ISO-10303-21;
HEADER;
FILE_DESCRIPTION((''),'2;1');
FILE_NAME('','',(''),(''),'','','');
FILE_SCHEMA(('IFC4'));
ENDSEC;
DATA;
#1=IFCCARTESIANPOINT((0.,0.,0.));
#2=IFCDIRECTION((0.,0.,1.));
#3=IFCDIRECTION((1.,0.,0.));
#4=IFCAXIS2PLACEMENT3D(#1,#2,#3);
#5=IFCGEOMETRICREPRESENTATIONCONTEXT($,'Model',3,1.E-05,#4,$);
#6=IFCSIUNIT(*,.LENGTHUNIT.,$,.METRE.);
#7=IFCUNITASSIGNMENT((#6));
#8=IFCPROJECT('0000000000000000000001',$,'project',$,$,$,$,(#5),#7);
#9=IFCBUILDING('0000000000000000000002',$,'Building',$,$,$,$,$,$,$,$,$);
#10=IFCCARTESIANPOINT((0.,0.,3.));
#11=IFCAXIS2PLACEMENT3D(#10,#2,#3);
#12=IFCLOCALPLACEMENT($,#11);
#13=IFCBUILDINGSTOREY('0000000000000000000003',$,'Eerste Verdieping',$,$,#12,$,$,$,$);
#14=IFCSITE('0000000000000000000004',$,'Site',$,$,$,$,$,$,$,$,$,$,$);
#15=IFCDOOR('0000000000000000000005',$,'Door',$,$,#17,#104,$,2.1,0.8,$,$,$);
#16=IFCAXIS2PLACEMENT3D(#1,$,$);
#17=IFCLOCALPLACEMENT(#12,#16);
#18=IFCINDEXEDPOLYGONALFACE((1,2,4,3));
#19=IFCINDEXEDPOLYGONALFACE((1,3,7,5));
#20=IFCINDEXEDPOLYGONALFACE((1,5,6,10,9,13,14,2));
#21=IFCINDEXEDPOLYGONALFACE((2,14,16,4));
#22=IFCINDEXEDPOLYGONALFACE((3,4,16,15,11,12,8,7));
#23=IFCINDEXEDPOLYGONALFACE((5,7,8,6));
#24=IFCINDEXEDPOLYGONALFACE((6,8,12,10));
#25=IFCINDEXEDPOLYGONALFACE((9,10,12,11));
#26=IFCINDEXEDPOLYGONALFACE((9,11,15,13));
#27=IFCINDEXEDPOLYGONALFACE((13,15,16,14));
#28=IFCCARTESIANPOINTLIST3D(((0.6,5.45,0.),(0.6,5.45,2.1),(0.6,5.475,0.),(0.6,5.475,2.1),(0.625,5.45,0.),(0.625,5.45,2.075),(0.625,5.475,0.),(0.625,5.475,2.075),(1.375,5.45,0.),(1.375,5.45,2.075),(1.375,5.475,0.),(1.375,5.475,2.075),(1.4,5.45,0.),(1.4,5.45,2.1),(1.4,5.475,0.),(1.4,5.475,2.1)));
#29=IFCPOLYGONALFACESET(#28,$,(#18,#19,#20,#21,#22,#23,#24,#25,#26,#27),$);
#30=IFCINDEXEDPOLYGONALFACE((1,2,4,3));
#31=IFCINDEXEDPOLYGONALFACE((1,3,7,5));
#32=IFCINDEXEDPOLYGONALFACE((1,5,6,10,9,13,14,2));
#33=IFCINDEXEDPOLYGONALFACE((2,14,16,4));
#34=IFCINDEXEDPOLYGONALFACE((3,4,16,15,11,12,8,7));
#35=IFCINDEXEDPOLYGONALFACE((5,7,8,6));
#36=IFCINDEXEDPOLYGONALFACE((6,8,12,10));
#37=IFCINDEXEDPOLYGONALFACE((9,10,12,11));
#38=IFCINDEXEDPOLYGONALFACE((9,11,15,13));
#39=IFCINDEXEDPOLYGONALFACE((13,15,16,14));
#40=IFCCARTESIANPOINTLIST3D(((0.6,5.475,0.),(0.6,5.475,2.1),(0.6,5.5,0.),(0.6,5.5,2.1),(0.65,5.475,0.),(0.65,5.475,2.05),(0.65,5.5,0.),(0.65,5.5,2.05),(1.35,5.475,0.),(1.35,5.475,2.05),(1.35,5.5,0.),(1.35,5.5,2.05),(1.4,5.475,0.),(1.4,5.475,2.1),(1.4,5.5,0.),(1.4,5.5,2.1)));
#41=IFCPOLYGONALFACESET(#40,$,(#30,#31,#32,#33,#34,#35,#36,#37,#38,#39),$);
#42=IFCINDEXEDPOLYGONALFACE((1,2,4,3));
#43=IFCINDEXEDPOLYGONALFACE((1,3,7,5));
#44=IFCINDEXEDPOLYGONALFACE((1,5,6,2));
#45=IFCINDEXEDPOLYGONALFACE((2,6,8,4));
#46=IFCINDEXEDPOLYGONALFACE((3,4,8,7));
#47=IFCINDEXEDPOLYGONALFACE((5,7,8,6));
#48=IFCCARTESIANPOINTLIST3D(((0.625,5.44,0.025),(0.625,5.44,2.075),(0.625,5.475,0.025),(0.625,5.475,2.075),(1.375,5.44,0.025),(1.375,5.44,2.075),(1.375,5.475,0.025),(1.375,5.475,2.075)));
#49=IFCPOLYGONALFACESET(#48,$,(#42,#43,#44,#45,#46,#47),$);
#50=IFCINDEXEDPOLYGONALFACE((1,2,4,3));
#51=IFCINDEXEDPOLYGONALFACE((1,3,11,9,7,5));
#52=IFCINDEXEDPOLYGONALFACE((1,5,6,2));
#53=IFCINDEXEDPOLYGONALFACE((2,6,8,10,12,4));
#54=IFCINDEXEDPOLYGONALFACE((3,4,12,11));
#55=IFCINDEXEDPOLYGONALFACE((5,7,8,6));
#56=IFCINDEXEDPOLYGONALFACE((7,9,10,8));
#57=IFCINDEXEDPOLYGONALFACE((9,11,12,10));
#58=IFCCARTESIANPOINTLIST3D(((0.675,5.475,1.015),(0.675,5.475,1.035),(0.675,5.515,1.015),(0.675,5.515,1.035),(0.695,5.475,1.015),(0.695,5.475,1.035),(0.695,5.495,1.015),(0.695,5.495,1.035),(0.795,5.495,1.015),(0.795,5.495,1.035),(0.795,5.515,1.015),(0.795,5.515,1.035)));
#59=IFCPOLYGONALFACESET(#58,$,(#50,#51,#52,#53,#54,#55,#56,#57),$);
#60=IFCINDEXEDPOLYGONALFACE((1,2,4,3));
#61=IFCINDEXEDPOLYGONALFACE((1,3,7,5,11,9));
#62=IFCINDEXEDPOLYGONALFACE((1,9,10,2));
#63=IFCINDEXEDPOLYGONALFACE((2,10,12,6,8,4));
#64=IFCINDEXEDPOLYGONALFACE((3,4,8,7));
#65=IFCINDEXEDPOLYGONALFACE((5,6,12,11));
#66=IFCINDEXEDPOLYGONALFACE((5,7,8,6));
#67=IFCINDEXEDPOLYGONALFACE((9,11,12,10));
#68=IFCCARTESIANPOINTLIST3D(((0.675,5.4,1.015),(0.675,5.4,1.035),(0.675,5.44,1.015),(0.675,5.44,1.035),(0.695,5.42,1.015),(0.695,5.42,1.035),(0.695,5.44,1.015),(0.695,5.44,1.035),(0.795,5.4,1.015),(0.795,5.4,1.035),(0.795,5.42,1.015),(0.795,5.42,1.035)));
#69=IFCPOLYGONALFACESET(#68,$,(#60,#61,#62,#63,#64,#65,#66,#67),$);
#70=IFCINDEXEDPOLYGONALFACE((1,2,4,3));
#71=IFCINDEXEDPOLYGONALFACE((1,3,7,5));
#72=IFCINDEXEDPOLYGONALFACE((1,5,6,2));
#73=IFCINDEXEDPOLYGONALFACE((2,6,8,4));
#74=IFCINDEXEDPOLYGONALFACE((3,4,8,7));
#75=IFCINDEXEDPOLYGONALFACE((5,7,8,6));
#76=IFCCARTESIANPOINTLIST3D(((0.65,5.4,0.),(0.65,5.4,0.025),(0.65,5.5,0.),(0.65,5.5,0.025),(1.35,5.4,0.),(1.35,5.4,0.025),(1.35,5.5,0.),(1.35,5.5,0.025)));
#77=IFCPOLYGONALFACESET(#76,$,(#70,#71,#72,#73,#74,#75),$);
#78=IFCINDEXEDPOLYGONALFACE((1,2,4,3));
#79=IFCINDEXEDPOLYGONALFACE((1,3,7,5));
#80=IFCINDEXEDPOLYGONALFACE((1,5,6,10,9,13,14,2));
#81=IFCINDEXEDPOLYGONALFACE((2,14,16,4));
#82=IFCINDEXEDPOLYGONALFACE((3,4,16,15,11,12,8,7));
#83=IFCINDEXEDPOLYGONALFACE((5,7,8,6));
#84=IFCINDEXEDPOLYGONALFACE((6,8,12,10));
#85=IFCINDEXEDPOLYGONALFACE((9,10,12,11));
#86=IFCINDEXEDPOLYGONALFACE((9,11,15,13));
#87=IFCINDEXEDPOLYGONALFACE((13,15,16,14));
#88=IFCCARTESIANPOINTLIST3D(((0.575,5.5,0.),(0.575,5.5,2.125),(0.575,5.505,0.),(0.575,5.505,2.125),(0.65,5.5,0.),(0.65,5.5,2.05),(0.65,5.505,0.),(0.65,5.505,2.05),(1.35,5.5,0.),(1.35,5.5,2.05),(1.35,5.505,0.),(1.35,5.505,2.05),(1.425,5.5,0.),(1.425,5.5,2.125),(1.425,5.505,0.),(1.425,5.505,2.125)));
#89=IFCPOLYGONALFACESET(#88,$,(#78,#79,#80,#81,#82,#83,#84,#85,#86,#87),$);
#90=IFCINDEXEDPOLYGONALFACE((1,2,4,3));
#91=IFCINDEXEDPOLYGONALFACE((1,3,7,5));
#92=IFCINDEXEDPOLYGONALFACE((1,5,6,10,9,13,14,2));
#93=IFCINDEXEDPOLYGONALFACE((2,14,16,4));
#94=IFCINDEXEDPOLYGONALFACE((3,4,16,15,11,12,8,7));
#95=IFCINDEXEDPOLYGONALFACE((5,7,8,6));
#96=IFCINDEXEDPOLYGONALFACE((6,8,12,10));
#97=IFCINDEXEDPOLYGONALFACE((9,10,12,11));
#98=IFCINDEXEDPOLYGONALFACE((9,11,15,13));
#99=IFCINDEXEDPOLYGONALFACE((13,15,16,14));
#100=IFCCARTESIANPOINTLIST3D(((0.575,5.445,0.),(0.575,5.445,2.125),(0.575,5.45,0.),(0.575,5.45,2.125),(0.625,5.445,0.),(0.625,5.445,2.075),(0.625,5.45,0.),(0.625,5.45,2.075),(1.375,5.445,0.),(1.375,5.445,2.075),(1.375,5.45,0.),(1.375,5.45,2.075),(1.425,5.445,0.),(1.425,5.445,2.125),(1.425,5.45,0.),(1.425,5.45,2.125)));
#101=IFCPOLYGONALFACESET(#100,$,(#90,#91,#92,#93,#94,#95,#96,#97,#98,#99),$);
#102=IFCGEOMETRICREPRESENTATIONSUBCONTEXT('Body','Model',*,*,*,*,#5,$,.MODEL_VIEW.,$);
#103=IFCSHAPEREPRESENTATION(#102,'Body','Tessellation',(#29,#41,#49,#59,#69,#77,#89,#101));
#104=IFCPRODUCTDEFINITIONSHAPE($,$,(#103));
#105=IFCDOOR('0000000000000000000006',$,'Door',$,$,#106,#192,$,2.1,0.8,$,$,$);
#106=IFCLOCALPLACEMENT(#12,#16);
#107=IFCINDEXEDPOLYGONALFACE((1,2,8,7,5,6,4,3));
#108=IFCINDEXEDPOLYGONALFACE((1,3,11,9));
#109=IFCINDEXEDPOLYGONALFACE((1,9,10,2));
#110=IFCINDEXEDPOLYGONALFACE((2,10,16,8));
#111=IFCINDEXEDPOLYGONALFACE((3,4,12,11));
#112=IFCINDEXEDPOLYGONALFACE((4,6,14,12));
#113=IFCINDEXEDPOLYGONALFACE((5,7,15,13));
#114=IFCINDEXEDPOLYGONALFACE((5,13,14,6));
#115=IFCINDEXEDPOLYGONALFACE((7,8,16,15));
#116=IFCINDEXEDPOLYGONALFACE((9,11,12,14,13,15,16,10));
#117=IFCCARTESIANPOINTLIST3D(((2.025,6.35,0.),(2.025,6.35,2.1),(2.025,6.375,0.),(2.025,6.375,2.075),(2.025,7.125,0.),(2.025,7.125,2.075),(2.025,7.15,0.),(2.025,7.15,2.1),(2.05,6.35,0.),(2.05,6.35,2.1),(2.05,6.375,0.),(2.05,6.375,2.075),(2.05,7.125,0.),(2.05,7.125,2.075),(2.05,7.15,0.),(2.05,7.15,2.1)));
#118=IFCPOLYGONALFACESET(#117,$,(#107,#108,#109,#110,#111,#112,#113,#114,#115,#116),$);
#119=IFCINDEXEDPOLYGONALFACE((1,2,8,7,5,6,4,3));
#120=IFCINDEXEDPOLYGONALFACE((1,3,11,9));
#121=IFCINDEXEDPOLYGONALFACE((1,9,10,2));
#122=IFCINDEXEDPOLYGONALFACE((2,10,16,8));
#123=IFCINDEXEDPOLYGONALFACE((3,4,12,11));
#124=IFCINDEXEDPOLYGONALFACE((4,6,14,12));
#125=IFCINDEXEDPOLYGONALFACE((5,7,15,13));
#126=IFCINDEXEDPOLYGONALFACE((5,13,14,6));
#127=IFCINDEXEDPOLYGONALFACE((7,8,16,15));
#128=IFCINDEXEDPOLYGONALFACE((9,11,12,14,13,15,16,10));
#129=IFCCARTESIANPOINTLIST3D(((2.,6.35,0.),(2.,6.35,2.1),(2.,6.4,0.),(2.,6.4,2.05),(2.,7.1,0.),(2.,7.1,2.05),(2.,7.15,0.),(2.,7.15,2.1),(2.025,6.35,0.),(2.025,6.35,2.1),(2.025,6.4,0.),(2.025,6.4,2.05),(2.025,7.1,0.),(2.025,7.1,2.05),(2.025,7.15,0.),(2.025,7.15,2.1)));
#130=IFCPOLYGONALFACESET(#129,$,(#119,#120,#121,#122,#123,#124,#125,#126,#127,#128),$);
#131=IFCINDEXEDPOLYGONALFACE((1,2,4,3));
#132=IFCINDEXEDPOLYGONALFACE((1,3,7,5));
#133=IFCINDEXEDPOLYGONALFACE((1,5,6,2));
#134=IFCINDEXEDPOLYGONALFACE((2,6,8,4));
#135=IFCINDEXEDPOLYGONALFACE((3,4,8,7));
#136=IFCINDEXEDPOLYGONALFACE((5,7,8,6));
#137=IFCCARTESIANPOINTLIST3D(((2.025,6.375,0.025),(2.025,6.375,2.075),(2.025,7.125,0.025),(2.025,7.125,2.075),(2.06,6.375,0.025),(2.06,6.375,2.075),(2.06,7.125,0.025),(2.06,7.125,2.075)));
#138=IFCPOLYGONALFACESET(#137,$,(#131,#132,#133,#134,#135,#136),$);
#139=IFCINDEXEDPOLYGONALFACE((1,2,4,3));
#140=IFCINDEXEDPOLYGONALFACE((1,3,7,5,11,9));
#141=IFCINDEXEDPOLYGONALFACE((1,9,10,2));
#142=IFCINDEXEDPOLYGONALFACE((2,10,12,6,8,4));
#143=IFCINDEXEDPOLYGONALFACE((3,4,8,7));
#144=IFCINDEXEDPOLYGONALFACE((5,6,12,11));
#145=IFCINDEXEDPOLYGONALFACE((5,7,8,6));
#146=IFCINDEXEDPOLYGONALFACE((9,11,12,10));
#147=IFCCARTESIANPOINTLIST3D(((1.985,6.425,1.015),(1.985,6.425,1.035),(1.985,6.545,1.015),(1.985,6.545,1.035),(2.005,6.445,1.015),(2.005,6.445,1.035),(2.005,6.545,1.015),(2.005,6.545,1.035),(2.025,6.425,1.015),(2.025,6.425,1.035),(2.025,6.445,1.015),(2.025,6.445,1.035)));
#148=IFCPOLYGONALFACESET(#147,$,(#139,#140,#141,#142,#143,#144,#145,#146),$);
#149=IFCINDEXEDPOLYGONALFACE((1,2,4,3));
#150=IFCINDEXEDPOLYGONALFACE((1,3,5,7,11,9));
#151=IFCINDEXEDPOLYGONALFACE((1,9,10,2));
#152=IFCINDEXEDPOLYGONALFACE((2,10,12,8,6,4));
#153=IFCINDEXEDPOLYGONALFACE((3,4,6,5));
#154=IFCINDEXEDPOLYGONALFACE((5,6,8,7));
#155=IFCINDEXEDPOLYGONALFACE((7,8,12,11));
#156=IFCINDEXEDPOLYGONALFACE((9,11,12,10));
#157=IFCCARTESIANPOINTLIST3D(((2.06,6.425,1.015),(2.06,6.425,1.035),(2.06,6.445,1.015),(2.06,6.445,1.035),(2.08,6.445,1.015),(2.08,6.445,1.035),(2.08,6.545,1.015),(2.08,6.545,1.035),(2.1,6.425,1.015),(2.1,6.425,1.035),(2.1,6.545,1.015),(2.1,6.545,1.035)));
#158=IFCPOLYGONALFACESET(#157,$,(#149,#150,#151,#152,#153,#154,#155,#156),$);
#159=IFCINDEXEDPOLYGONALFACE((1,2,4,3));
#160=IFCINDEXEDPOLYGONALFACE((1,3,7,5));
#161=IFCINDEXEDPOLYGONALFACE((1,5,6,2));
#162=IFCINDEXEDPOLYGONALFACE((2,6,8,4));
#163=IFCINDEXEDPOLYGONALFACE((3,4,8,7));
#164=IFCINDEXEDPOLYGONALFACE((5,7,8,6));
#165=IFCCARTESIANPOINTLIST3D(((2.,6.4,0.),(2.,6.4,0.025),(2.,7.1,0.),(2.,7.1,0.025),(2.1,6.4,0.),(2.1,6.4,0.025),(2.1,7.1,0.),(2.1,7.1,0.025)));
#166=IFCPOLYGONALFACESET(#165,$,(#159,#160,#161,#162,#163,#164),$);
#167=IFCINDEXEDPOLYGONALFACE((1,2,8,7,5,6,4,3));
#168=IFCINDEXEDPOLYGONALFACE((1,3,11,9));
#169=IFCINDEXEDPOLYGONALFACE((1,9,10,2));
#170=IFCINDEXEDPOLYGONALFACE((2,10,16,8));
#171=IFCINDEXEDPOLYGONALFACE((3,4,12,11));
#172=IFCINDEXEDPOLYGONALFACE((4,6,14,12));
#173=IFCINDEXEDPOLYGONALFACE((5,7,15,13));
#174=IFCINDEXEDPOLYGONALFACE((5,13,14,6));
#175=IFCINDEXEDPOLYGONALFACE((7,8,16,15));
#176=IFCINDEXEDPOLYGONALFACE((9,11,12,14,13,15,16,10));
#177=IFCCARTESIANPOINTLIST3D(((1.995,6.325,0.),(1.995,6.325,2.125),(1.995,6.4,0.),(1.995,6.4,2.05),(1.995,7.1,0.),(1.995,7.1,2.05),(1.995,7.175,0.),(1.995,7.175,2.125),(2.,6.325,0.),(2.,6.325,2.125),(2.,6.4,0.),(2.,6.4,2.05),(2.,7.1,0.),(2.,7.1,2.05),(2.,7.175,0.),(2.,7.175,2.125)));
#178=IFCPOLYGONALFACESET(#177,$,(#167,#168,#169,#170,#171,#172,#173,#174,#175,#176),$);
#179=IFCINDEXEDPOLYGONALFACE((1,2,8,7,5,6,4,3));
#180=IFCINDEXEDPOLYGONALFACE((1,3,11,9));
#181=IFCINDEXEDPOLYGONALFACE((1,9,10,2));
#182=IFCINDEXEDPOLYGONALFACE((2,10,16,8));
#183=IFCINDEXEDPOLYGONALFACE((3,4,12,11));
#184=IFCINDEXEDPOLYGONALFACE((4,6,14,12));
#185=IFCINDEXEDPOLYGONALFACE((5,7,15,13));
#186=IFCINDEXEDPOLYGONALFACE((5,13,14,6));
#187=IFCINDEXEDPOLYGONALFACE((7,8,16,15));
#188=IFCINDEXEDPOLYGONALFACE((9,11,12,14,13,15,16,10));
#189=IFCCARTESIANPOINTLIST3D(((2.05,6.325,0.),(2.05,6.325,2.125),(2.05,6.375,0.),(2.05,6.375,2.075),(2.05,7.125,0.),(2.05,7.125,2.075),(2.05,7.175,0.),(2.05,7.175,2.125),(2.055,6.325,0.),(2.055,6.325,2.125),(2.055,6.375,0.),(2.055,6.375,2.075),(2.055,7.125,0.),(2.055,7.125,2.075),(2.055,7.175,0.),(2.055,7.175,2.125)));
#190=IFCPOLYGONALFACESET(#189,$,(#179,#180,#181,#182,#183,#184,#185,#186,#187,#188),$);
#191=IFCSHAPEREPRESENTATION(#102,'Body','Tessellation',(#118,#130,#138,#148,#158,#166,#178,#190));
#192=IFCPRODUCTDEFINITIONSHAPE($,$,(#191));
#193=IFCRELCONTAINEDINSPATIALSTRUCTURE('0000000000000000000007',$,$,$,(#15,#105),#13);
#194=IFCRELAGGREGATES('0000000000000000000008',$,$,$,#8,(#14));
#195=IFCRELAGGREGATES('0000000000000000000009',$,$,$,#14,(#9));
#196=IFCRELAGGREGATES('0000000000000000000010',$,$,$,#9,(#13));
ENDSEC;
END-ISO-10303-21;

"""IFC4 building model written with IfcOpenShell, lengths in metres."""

from ifc_helpers import new_model, si_unit, frame, origin_with_axes, place, context, subcontext, project, spatial, line, indexed_curve, outline, extrude, element, save


model = new_model("IFC4")

# Units and contexts
model_context = context("Model", 3, precision=1e-05, world=origin_with_axes())
body_context = subcontext(model_context, "Body", "Model", "MODEL_VIEW")
ifc_project = project(units=[si_unit("LENGTHUNIT", "METRE")], contexts=[model_context])

# Site, building, storey
site = spatial("IfcSite", under=ifc_project, Name="Site")
building = spatial("IfcBuilding", under=site, Name="Building")
storey_placement = place(None, frame((0.0, 0.0, 3.0), z_axis=(0.0, 0.0, 1.0), x_axis=(1.0, 0.0, 0.0)))
storey = spatial("IfcBuildingStorey", under=building, at=storey_placement, Name="Eerste Verdieping")

# Doors
door_1_placement = place(storey_placement, frame((1.4, 5.5, 0.0), z_axis=(0.0, 0.0, 1.0), x_axis=(-1.0, 0.0, 0.0)))
element("IfcDoor", 1, at=door_1_placement, inside=storey, Name="Door", OverallHeight=2.1, OverallWidth=0.8, context=body_context, shape_type="SweptSolid", body=[
    extrude(outline(indexed_curve([(0.0, 0.0), (0.0, 2.1), (0.8, 2.1), (0.8, 0.0), (0.775, 0.0), (0.775, 2.075), (0.025, 2.075), (0.025, 0.0)], segments=[line(1, 2, 3, 4, 5, 6, 7, 8, 1)])), frame((0.0, 0.025, 0.0), z_axis=(0.0, -1.0, 0.0), x_axis=(1.0, 0.0, 0.0)), (0.0, 0.0, -1.0), 0.025),
    extrude(outline(indexed_curve([(0.0, 0.0), (0.0, 2.1), (0.8, 2.1), (0.8, 0.0), (0.75, 0.0), (0.75, 2.05), (0.05, 2.05), (0.05, 0.0)], segments=[line(1, 2, 3, 4, 5, 6, 7, 8, 1)])), frame((0.0, 0.0, 0.0), z_axis=(0.0, -1.0, 0.0), x_axis=(1.0, 0.0, 0.0)), (0.0, 0.0, -1.0), 0.025),
    extrude(outline(indexed_curve([(0.0, 0.0), (0.75, 0.0), (0.75, 0.035), (0.0, 0.035)], segments=[line(1, 2, 3, 4, 1)])), frame((0.025, 0.025, 0.025), z_axis=(0.0, 0.0, 1.0), x_axis=(1.0, 0.0, 0.0)), (0.0, 0.0, 1.0), 2.05),
    extrude(outline(indexed_curve([(0.0, 0.0), (0.0, -0.04), (-0.12, -0.04), (-0.12, -0.02), (-0.02, -0.02), (-0.02, 0.0)], segments=[line(1, 2, 3, 4, 5, 6, 1)])), frame((0.725, 0.025, 1.015), z_axis=(0.0, 0.0, 1.0), x_axis=(1.0, 0.0, 0.0)), (0.0, 0.0, 1.0), 0.02),
    extrude(outline(indexed_curve([(0.0, 0.0), (0.0, 0.04), (-0.12, 0.04), (-0.12, 0.02), (-0.02, 0.02), (-0.02, 0.0)], segments=[line(1, 2, 3, 4, 5, 6, 1)])), frame((0.725, 0.06, 1.015), z_axis=(0.0, 0.0, 1.0), x_axis=(1.0, 0.0, 0.0)), (0.0, 0.0, 1.0), 0.02),
    extrude(outline(indexed_curve([(0.0, 0.0), (0.7, 0.0), (0.7, 0.1), (0.0, 0.1)], segments=[line(1, 2, 3, 4, 1)])), frame((0.05, 0.0, 0.0), z_axis=(0.0, 0.0, 1.0), x_axis=(1.0, 0.0, 0.0)), (0.0, 0.0, 1.0), 0.025),
    extrude(outline(indexed_curve([(0.0, 0.0), (0.0, 2.125), (0.85, 2.125), (0.85, 0.0), (0.775, 0.0), (0.775, 2.05), (0.075, 2.05), (0.075, 0.0)], segments=[line(1, 2, 3, 4, 5, 6, 7, 8, 1)])), frame((-0.025, -0.005, 0.0), z_axis=(0.0, -1.0, 0.0), x_axis=(1.0, 0.0, 0.0)), (0.0, 0.0, -1.0), 0.005),
    extrude(outline(indexed_curve([(0.0, 0.0), (0.0, 2.125), (0.85, 2.125), (0.85, 0.0), (0.8, 0.0), (0.8, 2.075), (0.05, 2.075), (0.05, 0.0)], segments=[line(1, 2, 3, 4, 5, 6, 7, 8, 1)])), frame((-0.025, 0.05, 0.0), z_axis=(0.0, -1.0, 0.0), x_axis=(1.0, 0.0, 0.0)), (0.0, 0.0, -1.0), 0.005),
])
door_2_placement = place(storey_placement, frame((2.0, 7.15, 0.0), z_axis=(0.0, 0.0, 1.0), x_axis=(0.0, -1.0, 0.0)))
element("IfcDoor", 2, at=door_2_placement, inside=storey, Name="Door", OverallHeight=2.1, OverallWidth=0.8, context=body_context, shape_type="SweptSolid", body=[
    extrude(outline(indexed_curve([(0.0, 0.0), (0.0, 2.1), (0.8, 2.1), (0.8, 0.0), (0.775, 0.0), (0.775, 2.075), (0.025, 2.075), (0.025, 0.0)], segments=[line(1, 2, 3, 4, 5, 6, 7, 8, 1)])), frame((0.0, 0.025, 0.0), z_axis=(0.0, -1.0, 0.0), x_axis=(1.0, 0.0, 0.0)), (0.0, 0.0, -1.0), 0.025),
    extrude(outline(indexed_curve([(0.0, 0.0), (0.0, 2.1), (0.8, 2.1), (0.8, 0.0), (0.75, 0.0), (0.75, 2.05), (0.05, 2.05), (0.05, 0.0)], segments=[line(1, 2, 3, 4, 5, 6, 7, 8, 1)])), frame((0.0, 0.0, 0.0), z_axis=(0.0, -1.0, 0.0), x_axis=(1.0, 0.0, 0.0)), (0.0, 0.0, -1.0), 0.025),
    extrude(outline(indexed_curve([(0.0, 0.0), (0.75, 0.0), (0.75, 0.035), (0.0, 0.035)], segments=[line(1, 2, 3, 4, 1)])), frame((0.025, 0.025, 0.025), z_axis=(0.0, 0.0, 1.0), x_axis=(1.0, 0.0, 0.0)), (0.0, 0.0, 1.0), 2.05),
    extrude(outline(indexed_curve([(0.0, 0.0), (0.0, -0.04), (-0.12, -0.04), (-0.12, -0.02), (-0.02, -0.02), (-0.02, 0.0)], segments=[line(1, 2, 3, 4, 5, 6, 1)])), frame((0.725, 0.025, 1.015), z_axis=(0.0, 0.0, 1.0), x_axis=(1.0, 0.0, 0.0)), (0.0, 0.0, 1.0), 0.02),
    extrude(outline(indexed_curve([(0.0, 0.0), (0.0, 0.04), (-0.12, 0.04), (-0.12, 0.02), (-0.02, 0.02), (-0.02, 0.0)], segments=[line(1, 2, 3, 4, 5, 6, 1)])), frame((0.725, 0.06, 1.015), z_axis=(0.0, 0.0, 1.0), x_axis=(1.0, 0.0, 0.0)), (0.0, 0.0, 1.0), 0.02),
    extrude(outline(indexed_curve([(0.0, 0.0), (0.7, 0.0), (0.7, 0.1), (0.0, 0.1)], segments=[line(1, 2, 3, 4, 1)])), frame((0.05, 0.0, 0.0), z_axis=(0.0, 0.0, 1.0), x_axis=(1.0, 0.0, 0.0)), (0.0, 0.0, 1.0), 0.025),
    extrude(outline(indexed_curve([(0.0, 0.0), (0.0, 2.125), (0.85, 2.125), (0.85, 0.0), (0.775, 0.0), (0.775, 2.05), (0.075, 2.05), (0.075, 0.0)], segments=[line(1, 2, 3, 4, 5, 6, 7, 8, 1)])), frame((-0.025, -0.005, 0.0), z_axis=(0.0, -1.0, 0.0), x_axis=(1.0, 0.0, 0.0)), (0.0, 0.0, -1.0), 0.005),
    extrude(outline(indexed_curve([(0.0, 0.0), (0.0, 2.125), (0.85, 2.125), (0.85, 0.0), (0.8, 0.0), (0.8, 2.075), (0.05, 2.075), (0.05, 0.0)], segments=[line(1, 2, 3, 4, 5, 6, 7, 8, 1)])), frame((-0.025, 0.05, 0.0), z_axis=(0.0, -1.0, 0.0), x_axis=(1.0, 0.0, 0.0)), (0.0, 0.0, -1.0), 0.005),
])

save(model, "model.ifc")
